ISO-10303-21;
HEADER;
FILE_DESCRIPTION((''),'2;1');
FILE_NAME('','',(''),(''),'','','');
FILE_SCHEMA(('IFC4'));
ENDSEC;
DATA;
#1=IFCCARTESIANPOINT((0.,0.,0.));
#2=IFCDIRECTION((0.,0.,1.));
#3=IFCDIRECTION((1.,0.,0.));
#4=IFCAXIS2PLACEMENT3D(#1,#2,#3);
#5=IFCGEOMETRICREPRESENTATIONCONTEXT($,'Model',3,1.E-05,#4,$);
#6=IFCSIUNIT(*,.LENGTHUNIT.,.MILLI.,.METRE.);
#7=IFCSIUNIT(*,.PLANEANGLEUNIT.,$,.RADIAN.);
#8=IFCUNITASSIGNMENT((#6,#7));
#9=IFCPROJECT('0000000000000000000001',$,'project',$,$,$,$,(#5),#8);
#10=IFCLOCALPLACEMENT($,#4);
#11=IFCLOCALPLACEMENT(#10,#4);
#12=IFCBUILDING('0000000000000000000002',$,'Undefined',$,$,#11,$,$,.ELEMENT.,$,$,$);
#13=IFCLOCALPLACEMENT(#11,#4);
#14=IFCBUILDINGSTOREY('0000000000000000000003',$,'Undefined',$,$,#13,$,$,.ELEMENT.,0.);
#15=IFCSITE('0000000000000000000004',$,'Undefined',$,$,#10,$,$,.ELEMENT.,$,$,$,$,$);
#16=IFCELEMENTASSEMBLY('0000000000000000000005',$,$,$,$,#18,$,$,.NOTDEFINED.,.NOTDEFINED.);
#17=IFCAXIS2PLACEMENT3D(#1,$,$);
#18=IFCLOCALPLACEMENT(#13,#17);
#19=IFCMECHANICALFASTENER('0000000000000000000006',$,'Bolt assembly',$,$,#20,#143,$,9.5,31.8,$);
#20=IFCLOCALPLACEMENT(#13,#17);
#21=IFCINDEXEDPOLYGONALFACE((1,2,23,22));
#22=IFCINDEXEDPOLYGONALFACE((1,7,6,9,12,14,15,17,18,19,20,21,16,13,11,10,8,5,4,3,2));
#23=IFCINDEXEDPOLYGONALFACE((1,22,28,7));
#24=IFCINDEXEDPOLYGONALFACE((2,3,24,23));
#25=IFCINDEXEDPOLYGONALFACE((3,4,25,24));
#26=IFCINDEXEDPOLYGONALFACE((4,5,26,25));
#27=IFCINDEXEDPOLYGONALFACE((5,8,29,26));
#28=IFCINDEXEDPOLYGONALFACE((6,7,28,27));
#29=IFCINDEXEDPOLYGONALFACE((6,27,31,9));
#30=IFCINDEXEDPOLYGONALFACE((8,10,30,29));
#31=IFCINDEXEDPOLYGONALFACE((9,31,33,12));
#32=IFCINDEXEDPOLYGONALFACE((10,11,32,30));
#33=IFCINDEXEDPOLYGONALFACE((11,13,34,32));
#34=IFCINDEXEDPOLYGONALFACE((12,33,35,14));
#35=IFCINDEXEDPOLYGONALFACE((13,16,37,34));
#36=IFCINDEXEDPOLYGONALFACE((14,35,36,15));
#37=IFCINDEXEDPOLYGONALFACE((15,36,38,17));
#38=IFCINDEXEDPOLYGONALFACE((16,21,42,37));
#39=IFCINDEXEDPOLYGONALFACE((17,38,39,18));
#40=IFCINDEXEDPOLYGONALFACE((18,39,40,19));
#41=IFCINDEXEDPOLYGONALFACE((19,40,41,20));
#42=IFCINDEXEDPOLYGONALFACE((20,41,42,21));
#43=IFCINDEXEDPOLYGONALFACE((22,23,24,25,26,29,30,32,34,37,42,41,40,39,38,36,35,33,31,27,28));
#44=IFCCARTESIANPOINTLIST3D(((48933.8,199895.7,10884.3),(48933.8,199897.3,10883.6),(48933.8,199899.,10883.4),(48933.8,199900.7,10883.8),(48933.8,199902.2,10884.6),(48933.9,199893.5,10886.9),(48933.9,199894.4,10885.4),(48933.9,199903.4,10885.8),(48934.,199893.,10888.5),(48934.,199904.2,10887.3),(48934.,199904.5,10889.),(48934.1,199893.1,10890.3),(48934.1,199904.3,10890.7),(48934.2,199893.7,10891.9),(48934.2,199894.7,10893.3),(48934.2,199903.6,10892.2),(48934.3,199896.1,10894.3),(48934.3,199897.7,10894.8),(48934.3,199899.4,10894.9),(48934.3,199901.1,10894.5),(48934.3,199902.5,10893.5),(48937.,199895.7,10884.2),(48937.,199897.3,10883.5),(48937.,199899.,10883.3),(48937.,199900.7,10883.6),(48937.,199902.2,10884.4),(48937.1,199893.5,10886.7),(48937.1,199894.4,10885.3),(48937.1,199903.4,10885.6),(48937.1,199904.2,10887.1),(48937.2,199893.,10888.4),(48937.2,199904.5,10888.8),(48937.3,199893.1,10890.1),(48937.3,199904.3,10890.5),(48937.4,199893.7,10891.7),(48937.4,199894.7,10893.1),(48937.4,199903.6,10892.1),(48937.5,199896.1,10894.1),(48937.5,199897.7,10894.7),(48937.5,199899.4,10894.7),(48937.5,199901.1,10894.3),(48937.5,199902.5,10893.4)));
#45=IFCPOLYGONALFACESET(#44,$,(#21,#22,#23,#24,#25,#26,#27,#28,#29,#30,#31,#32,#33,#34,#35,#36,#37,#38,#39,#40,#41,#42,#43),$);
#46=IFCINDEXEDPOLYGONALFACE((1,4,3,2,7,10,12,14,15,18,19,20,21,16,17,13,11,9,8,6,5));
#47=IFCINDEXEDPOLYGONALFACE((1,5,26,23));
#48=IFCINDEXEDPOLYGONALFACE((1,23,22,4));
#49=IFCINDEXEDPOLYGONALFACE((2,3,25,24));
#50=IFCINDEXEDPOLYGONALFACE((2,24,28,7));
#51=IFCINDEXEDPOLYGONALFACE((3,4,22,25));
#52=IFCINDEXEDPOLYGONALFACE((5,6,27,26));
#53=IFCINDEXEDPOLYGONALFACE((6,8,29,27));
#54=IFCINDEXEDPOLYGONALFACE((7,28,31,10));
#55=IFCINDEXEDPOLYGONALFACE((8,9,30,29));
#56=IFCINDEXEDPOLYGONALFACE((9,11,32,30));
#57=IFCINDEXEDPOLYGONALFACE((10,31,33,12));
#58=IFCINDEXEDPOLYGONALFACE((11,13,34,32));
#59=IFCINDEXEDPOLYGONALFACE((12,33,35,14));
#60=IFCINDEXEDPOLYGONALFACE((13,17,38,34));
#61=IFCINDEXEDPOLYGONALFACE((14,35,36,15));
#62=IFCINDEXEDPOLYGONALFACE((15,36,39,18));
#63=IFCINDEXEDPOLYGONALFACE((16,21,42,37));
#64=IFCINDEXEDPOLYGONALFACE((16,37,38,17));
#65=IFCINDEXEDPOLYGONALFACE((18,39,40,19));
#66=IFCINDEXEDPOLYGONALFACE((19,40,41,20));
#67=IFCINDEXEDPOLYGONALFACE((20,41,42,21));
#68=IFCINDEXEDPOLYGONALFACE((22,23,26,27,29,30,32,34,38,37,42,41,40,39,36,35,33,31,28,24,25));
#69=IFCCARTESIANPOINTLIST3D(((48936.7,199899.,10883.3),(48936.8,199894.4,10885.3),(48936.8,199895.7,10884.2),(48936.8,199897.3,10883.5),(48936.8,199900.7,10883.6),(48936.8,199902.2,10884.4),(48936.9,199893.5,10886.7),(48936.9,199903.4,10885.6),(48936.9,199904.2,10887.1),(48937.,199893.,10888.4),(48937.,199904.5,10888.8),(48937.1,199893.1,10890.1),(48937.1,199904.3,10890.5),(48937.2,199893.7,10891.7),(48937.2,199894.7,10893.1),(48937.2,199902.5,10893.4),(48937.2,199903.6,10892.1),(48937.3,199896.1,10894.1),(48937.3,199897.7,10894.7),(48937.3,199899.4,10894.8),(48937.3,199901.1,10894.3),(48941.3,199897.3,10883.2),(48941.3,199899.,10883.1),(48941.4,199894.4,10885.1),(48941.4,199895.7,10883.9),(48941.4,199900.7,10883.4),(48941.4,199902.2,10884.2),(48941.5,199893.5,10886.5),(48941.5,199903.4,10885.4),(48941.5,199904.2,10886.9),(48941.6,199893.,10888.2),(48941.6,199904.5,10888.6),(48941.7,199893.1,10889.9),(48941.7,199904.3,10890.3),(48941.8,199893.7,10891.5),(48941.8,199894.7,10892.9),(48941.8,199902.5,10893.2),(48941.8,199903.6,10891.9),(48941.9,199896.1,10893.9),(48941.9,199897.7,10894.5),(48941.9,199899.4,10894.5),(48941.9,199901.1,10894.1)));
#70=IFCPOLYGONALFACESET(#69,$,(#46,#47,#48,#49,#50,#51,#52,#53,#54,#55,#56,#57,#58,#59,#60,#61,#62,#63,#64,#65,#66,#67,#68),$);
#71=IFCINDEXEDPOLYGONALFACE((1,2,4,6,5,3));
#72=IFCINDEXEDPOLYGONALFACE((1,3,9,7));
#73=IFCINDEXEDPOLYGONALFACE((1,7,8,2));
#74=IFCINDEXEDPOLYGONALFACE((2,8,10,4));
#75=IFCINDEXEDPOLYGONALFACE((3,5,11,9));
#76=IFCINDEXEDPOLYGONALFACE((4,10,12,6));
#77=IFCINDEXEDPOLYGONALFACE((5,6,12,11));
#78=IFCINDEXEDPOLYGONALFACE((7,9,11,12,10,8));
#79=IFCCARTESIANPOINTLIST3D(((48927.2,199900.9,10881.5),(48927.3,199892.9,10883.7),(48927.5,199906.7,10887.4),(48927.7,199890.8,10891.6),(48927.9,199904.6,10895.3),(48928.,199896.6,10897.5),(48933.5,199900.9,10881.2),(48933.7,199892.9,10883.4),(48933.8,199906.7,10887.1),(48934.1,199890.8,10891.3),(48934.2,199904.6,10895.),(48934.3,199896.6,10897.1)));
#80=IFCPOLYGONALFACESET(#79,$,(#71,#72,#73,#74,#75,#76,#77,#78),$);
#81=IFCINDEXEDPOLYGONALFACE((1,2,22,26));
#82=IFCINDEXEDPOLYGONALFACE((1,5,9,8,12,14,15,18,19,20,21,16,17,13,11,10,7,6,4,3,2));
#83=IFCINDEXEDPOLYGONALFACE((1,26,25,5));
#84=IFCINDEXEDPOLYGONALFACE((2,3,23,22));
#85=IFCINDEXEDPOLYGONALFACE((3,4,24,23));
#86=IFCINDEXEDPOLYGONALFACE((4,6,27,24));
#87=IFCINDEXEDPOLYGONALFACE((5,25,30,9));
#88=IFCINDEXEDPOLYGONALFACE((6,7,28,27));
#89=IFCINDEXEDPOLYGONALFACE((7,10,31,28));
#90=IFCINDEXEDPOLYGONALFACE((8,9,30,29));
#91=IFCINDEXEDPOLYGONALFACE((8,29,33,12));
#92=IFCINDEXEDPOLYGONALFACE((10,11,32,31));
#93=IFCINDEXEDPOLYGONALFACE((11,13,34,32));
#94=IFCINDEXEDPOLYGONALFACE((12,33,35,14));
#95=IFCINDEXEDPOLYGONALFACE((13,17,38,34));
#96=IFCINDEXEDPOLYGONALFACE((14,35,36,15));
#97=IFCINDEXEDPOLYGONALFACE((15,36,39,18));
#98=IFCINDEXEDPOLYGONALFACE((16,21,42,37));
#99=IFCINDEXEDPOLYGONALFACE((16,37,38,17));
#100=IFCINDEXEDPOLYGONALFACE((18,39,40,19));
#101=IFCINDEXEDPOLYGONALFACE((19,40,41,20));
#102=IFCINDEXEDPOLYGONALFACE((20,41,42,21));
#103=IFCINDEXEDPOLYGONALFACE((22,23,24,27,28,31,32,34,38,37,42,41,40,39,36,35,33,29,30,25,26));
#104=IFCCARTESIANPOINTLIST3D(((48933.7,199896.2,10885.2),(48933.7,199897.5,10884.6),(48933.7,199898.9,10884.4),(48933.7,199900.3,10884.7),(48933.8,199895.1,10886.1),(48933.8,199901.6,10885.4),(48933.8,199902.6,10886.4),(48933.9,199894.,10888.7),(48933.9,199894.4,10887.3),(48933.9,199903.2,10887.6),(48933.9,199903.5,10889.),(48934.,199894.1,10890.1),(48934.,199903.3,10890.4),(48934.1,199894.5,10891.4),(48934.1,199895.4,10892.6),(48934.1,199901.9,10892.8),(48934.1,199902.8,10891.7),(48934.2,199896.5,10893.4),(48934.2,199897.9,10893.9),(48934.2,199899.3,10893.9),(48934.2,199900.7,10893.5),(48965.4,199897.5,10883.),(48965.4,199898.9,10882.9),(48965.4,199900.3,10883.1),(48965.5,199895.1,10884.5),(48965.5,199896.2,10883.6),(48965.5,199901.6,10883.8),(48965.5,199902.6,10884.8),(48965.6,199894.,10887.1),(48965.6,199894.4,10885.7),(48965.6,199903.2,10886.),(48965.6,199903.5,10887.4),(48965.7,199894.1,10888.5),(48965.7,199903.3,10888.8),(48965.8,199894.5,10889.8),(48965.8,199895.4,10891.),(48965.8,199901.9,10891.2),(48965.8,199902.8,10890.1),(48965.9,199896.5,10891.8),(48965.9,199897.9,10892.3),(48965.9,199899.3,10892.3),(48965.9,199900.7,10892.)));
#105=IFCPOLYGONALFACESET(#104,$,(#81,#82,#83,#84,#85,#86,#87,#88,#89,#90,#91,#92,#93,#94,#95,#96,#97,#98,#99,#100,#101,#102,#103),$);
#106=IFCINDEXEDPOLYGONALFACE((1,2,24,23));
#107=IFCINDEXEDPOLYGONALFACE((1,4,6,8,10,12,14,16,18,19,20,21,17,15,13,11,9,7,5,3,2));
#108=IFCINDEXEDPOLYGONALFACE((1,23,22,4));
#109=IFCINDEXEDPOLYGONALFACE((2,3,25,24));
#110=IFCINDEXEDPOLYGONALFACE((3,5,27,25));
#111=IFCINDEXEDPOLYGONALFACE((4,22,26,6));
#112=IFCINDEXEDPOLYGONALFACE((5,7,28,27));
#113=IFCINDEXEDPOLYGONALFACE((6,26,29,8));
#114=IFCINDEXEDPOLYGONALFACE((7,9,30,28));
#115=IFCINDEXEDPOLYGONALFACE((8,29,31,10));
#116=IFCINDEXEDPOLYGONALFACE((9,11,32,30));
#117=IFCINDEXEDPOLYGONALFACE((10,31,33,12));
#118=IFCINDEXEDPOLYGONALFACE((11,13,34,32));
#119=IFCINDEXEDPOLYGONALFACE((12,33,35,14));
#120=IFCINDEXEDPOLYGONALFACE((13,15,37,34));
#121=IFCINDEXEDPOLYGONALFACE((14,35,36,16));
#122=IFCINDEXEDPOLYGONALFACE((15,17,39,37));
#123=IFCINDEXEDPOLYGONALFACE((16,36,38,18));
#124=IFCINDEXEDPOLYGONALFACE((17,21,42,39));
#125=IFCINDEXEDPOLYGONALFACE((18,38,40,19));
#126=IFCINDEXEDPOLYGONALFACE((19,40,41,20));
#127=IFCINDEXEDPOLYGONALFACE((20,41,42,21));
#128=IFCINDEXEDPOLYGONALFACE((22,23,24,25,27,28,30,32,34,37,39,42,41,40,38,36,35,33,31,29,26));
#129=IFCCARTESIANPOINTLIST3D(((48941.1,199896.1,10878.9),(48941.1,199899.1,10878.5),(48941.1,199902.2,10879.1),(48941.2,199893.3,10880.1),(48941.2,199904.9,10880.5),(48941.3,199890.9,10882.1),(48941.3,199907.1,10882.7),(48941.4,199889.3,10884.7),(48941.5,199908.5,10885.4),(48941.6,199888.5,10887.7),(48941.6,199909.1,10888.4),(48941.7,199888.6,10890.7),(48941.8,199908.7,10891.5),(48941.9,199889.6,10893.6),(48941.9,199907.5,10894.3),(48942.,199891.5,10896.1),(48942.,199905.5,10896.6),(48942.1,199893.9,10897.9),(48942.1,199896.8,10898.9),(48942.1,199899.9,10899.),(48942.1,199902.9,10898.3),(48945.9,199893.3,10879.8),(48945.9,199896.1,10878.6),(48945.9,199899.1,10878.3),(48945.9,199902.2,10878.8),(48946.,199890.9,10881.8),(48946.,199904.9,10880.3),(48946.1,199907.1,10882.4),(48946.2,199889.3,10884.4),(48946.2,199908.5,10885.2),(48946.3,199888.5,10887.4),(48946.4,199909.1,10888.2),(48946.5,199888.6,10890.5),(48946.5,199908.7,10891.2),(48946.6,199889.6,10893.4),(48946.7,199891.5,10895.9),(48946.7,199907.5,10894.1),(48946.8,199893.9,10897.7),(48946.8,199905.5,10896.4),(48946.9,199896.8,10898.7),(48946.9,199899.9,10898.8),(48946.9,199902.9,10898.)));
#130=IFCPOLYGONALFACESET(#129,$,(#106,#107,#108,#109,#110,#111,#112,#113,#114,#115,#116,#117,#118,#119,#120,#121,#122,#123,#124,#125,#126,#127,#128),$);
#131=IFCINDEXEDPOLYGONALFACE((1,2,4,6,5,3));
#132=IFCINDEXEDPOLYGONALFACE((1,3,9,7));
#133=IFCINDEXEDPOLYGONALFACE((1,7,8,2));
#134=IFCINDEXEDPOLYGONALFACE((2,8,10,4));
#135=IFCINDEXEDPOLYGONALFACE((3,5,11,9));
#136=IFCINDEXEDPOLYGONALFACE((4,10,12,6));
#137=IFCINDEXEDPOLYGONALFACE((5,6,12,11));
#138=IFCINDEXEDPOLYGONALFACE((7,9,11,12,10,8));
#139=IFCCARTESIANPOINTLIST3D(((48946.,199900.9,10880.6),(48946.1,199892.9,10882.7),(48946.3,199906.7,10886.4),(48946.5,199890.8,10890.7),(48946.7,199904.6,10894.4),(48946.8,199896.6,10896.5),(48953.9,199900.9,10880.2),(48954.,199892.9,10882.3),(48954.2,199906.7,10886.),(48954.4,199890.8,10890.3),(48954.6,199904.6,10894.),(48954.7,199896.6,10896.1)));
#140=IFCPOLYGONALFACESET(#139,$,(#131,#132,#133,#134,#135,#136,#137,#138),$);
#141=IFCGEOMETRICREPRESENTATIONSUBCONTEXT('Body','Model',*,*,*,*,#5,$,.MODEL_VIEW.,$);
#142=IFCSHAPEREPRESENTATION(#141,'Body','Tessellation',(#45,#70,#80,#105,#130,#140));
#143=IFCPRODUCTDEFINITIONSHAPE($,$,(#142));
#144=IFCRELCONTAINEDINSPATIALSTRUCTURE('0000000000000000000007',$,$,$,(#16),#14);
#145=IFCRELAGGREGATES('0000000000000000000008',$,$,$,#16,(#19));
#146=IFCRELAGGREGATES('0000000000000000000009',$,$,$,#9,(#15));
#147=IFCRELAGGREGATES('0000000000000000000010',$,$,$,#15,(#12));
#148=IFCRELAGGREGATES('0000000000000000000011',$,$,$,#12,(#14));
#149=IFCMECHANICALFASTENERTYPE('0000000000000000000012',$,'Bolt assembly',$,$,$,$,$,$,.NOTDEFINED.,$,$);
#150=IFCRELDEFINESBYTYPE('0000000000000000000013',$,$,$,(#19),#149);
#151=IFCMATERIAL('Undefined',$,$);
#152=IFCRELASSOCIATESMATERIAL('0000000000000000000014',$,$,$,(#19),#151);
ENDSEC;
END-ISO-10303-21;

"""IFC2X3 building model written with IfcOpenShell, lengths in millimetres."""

from ifc_helpers import new_model, si_unit, frame, origin_with_axes, origin_2d_with_axis, place, context, subcontext, project, spatial, polyline, circle, outline, extrude, source, transform, mapped, material, type_object, element, aggregate, save


model = new_model("IFC2X3")

# Units and contexts
model_context = context("Model", 3, precision=1e-05, world=origin_with_axes())
body_context = subcontext(model_context, "Body", "Model", "MODEL_VIEW")
ifc_project = project(units=[si_unit("LENGTHUNIT", "METRE", prefix="MILLI"), si_unit("PLANEANGLEUNIT", "RADIAN")], contexts=[model_context])

# Site, building, storey
site_placement = place(None, origin_with_axes())
site = spatial("IfcSite", under=ifc_project, at=site_placement, Name="Undefined", CompositionType="ELEMENT")
building_placement = place(site_placement, origin_with_axes())
building = spatial("IfcBuilding", under=site, at=building_placement, Name="Undefined", CompositionType="ELEMENT")
storey_placement = place(building_placement, origin_with_axes())
storey = spatial("IfcBuildingStorey", under=building, at=storey_placement, Name="Undefined", CompositionType="ELEMENT", Elevation=0.0)

# Shared definitions
ifc_material_1 = material(Name="Undefined")
mechanical_fastener_type = type_object("IfcMechanicalFastenerType", Name="Bolt assembly")

# Element assembly, mechanical fastener
assembly_1_placement = place(storey_placement, origin_with_axes())
assembly_1 = element("IfcElementAssembly", 1, at=assembly_1_placement, inside=storey, AssemblyPlace="NOTDEFINED", PredefinedType="NOTDEFINED")
shared_shape_1 = source(origin_with_axes(), body_context, "Body", "SweptSolid", [
    extrude(circle(Radius=5.8, at=origin_2d_with_axis()), frame((0.0, -7.6, 0.0), z_axis=(0.0, 1.0, 0.0), x_axis=(1.0, 0.0, 0.0)), (0.0, 0.0, 1.0), 3.2),
    extrude(circle(Radius=5.8, at=origin_2d_with_axis()), frame((0.0, -4.6, 0.0), z_axis=(0.0, 1.0, 0.0), x_axis=(1.0, 0.0, 0.0)), (0.0, 0.0, 1.0), 4.6),
    extrude(outline(polyline([(7.1, -4.1), (7.1, 4.1), (0.0, 8.2), (-7.1, 4.1), (-7.1, -4.1), (0.0, -8.2), (7.1, -4.1)])), frame((0.0, -14.0, 0.0), z_axis=(0.0, 1.0, 0.0), x_axis=(1.0, 0.0, 0.0)), (0.0, 0.0, 1.0), 6.3),
    extrude(circle(Radius=4.8, at=origin_2d_with_axis()), frame((0.0, -7.7, 0.0), z_axis=(0.0, 1.0, 0.0), x_axis=(1.0, 0.0, 0.0)), (0.0, 0.0, 1.0), 31.8),
    extrude(circle(Radius=10.3, at=origin_2d_with_axis()), frame((0.0, 0.0, 0.0), z_axis=(0.0, 1.0, 0.0), x_axis=(1.0, 0.0, 0.0)), (0.0, 0.0, 1.0), 4.8),
    extrude(outline(polyline([(7.1, -4.1), (7.1, 4.1), (0.0, 8.2), (-7.1, 4.1), (-7.1, -4.1), (0.0, -8.2), (7.1, -4.1)])), frame((0.0, 4.8, 0.0), z_axis=(0.0, 1.0, 0.0), x_axis=(1.0, 0.0, 0.0)), (0.0, 0.0, 1.0), 7.9),
])
mechanical_fastener_1_placement = place(assembly_1_placement, frame((48941.6, 199898.8, 10888.8), z_axis=(0.035281, 0.707107, 0.706226), x_axis=(0.035282, -0.707107, 0.706226)))
mechanical_fastener_1 = element("IfcMechanicalFastener", 2, at=mechanical_fastener_1_placement, type_object=mechanical_fastener_type, material=ifc_material_1, Name="Bolt assembly", NominalDiameter=9.5, NominalLength=31.8, context=body_context, shape_type="MappedRepresentation", body=[
    mapped(shared_shape_1, transform((0.0, 0.0, 0.0))),
])
aggregate(assembly_1, [mechanical_fastener_1])

save(model, "model.ifc")
